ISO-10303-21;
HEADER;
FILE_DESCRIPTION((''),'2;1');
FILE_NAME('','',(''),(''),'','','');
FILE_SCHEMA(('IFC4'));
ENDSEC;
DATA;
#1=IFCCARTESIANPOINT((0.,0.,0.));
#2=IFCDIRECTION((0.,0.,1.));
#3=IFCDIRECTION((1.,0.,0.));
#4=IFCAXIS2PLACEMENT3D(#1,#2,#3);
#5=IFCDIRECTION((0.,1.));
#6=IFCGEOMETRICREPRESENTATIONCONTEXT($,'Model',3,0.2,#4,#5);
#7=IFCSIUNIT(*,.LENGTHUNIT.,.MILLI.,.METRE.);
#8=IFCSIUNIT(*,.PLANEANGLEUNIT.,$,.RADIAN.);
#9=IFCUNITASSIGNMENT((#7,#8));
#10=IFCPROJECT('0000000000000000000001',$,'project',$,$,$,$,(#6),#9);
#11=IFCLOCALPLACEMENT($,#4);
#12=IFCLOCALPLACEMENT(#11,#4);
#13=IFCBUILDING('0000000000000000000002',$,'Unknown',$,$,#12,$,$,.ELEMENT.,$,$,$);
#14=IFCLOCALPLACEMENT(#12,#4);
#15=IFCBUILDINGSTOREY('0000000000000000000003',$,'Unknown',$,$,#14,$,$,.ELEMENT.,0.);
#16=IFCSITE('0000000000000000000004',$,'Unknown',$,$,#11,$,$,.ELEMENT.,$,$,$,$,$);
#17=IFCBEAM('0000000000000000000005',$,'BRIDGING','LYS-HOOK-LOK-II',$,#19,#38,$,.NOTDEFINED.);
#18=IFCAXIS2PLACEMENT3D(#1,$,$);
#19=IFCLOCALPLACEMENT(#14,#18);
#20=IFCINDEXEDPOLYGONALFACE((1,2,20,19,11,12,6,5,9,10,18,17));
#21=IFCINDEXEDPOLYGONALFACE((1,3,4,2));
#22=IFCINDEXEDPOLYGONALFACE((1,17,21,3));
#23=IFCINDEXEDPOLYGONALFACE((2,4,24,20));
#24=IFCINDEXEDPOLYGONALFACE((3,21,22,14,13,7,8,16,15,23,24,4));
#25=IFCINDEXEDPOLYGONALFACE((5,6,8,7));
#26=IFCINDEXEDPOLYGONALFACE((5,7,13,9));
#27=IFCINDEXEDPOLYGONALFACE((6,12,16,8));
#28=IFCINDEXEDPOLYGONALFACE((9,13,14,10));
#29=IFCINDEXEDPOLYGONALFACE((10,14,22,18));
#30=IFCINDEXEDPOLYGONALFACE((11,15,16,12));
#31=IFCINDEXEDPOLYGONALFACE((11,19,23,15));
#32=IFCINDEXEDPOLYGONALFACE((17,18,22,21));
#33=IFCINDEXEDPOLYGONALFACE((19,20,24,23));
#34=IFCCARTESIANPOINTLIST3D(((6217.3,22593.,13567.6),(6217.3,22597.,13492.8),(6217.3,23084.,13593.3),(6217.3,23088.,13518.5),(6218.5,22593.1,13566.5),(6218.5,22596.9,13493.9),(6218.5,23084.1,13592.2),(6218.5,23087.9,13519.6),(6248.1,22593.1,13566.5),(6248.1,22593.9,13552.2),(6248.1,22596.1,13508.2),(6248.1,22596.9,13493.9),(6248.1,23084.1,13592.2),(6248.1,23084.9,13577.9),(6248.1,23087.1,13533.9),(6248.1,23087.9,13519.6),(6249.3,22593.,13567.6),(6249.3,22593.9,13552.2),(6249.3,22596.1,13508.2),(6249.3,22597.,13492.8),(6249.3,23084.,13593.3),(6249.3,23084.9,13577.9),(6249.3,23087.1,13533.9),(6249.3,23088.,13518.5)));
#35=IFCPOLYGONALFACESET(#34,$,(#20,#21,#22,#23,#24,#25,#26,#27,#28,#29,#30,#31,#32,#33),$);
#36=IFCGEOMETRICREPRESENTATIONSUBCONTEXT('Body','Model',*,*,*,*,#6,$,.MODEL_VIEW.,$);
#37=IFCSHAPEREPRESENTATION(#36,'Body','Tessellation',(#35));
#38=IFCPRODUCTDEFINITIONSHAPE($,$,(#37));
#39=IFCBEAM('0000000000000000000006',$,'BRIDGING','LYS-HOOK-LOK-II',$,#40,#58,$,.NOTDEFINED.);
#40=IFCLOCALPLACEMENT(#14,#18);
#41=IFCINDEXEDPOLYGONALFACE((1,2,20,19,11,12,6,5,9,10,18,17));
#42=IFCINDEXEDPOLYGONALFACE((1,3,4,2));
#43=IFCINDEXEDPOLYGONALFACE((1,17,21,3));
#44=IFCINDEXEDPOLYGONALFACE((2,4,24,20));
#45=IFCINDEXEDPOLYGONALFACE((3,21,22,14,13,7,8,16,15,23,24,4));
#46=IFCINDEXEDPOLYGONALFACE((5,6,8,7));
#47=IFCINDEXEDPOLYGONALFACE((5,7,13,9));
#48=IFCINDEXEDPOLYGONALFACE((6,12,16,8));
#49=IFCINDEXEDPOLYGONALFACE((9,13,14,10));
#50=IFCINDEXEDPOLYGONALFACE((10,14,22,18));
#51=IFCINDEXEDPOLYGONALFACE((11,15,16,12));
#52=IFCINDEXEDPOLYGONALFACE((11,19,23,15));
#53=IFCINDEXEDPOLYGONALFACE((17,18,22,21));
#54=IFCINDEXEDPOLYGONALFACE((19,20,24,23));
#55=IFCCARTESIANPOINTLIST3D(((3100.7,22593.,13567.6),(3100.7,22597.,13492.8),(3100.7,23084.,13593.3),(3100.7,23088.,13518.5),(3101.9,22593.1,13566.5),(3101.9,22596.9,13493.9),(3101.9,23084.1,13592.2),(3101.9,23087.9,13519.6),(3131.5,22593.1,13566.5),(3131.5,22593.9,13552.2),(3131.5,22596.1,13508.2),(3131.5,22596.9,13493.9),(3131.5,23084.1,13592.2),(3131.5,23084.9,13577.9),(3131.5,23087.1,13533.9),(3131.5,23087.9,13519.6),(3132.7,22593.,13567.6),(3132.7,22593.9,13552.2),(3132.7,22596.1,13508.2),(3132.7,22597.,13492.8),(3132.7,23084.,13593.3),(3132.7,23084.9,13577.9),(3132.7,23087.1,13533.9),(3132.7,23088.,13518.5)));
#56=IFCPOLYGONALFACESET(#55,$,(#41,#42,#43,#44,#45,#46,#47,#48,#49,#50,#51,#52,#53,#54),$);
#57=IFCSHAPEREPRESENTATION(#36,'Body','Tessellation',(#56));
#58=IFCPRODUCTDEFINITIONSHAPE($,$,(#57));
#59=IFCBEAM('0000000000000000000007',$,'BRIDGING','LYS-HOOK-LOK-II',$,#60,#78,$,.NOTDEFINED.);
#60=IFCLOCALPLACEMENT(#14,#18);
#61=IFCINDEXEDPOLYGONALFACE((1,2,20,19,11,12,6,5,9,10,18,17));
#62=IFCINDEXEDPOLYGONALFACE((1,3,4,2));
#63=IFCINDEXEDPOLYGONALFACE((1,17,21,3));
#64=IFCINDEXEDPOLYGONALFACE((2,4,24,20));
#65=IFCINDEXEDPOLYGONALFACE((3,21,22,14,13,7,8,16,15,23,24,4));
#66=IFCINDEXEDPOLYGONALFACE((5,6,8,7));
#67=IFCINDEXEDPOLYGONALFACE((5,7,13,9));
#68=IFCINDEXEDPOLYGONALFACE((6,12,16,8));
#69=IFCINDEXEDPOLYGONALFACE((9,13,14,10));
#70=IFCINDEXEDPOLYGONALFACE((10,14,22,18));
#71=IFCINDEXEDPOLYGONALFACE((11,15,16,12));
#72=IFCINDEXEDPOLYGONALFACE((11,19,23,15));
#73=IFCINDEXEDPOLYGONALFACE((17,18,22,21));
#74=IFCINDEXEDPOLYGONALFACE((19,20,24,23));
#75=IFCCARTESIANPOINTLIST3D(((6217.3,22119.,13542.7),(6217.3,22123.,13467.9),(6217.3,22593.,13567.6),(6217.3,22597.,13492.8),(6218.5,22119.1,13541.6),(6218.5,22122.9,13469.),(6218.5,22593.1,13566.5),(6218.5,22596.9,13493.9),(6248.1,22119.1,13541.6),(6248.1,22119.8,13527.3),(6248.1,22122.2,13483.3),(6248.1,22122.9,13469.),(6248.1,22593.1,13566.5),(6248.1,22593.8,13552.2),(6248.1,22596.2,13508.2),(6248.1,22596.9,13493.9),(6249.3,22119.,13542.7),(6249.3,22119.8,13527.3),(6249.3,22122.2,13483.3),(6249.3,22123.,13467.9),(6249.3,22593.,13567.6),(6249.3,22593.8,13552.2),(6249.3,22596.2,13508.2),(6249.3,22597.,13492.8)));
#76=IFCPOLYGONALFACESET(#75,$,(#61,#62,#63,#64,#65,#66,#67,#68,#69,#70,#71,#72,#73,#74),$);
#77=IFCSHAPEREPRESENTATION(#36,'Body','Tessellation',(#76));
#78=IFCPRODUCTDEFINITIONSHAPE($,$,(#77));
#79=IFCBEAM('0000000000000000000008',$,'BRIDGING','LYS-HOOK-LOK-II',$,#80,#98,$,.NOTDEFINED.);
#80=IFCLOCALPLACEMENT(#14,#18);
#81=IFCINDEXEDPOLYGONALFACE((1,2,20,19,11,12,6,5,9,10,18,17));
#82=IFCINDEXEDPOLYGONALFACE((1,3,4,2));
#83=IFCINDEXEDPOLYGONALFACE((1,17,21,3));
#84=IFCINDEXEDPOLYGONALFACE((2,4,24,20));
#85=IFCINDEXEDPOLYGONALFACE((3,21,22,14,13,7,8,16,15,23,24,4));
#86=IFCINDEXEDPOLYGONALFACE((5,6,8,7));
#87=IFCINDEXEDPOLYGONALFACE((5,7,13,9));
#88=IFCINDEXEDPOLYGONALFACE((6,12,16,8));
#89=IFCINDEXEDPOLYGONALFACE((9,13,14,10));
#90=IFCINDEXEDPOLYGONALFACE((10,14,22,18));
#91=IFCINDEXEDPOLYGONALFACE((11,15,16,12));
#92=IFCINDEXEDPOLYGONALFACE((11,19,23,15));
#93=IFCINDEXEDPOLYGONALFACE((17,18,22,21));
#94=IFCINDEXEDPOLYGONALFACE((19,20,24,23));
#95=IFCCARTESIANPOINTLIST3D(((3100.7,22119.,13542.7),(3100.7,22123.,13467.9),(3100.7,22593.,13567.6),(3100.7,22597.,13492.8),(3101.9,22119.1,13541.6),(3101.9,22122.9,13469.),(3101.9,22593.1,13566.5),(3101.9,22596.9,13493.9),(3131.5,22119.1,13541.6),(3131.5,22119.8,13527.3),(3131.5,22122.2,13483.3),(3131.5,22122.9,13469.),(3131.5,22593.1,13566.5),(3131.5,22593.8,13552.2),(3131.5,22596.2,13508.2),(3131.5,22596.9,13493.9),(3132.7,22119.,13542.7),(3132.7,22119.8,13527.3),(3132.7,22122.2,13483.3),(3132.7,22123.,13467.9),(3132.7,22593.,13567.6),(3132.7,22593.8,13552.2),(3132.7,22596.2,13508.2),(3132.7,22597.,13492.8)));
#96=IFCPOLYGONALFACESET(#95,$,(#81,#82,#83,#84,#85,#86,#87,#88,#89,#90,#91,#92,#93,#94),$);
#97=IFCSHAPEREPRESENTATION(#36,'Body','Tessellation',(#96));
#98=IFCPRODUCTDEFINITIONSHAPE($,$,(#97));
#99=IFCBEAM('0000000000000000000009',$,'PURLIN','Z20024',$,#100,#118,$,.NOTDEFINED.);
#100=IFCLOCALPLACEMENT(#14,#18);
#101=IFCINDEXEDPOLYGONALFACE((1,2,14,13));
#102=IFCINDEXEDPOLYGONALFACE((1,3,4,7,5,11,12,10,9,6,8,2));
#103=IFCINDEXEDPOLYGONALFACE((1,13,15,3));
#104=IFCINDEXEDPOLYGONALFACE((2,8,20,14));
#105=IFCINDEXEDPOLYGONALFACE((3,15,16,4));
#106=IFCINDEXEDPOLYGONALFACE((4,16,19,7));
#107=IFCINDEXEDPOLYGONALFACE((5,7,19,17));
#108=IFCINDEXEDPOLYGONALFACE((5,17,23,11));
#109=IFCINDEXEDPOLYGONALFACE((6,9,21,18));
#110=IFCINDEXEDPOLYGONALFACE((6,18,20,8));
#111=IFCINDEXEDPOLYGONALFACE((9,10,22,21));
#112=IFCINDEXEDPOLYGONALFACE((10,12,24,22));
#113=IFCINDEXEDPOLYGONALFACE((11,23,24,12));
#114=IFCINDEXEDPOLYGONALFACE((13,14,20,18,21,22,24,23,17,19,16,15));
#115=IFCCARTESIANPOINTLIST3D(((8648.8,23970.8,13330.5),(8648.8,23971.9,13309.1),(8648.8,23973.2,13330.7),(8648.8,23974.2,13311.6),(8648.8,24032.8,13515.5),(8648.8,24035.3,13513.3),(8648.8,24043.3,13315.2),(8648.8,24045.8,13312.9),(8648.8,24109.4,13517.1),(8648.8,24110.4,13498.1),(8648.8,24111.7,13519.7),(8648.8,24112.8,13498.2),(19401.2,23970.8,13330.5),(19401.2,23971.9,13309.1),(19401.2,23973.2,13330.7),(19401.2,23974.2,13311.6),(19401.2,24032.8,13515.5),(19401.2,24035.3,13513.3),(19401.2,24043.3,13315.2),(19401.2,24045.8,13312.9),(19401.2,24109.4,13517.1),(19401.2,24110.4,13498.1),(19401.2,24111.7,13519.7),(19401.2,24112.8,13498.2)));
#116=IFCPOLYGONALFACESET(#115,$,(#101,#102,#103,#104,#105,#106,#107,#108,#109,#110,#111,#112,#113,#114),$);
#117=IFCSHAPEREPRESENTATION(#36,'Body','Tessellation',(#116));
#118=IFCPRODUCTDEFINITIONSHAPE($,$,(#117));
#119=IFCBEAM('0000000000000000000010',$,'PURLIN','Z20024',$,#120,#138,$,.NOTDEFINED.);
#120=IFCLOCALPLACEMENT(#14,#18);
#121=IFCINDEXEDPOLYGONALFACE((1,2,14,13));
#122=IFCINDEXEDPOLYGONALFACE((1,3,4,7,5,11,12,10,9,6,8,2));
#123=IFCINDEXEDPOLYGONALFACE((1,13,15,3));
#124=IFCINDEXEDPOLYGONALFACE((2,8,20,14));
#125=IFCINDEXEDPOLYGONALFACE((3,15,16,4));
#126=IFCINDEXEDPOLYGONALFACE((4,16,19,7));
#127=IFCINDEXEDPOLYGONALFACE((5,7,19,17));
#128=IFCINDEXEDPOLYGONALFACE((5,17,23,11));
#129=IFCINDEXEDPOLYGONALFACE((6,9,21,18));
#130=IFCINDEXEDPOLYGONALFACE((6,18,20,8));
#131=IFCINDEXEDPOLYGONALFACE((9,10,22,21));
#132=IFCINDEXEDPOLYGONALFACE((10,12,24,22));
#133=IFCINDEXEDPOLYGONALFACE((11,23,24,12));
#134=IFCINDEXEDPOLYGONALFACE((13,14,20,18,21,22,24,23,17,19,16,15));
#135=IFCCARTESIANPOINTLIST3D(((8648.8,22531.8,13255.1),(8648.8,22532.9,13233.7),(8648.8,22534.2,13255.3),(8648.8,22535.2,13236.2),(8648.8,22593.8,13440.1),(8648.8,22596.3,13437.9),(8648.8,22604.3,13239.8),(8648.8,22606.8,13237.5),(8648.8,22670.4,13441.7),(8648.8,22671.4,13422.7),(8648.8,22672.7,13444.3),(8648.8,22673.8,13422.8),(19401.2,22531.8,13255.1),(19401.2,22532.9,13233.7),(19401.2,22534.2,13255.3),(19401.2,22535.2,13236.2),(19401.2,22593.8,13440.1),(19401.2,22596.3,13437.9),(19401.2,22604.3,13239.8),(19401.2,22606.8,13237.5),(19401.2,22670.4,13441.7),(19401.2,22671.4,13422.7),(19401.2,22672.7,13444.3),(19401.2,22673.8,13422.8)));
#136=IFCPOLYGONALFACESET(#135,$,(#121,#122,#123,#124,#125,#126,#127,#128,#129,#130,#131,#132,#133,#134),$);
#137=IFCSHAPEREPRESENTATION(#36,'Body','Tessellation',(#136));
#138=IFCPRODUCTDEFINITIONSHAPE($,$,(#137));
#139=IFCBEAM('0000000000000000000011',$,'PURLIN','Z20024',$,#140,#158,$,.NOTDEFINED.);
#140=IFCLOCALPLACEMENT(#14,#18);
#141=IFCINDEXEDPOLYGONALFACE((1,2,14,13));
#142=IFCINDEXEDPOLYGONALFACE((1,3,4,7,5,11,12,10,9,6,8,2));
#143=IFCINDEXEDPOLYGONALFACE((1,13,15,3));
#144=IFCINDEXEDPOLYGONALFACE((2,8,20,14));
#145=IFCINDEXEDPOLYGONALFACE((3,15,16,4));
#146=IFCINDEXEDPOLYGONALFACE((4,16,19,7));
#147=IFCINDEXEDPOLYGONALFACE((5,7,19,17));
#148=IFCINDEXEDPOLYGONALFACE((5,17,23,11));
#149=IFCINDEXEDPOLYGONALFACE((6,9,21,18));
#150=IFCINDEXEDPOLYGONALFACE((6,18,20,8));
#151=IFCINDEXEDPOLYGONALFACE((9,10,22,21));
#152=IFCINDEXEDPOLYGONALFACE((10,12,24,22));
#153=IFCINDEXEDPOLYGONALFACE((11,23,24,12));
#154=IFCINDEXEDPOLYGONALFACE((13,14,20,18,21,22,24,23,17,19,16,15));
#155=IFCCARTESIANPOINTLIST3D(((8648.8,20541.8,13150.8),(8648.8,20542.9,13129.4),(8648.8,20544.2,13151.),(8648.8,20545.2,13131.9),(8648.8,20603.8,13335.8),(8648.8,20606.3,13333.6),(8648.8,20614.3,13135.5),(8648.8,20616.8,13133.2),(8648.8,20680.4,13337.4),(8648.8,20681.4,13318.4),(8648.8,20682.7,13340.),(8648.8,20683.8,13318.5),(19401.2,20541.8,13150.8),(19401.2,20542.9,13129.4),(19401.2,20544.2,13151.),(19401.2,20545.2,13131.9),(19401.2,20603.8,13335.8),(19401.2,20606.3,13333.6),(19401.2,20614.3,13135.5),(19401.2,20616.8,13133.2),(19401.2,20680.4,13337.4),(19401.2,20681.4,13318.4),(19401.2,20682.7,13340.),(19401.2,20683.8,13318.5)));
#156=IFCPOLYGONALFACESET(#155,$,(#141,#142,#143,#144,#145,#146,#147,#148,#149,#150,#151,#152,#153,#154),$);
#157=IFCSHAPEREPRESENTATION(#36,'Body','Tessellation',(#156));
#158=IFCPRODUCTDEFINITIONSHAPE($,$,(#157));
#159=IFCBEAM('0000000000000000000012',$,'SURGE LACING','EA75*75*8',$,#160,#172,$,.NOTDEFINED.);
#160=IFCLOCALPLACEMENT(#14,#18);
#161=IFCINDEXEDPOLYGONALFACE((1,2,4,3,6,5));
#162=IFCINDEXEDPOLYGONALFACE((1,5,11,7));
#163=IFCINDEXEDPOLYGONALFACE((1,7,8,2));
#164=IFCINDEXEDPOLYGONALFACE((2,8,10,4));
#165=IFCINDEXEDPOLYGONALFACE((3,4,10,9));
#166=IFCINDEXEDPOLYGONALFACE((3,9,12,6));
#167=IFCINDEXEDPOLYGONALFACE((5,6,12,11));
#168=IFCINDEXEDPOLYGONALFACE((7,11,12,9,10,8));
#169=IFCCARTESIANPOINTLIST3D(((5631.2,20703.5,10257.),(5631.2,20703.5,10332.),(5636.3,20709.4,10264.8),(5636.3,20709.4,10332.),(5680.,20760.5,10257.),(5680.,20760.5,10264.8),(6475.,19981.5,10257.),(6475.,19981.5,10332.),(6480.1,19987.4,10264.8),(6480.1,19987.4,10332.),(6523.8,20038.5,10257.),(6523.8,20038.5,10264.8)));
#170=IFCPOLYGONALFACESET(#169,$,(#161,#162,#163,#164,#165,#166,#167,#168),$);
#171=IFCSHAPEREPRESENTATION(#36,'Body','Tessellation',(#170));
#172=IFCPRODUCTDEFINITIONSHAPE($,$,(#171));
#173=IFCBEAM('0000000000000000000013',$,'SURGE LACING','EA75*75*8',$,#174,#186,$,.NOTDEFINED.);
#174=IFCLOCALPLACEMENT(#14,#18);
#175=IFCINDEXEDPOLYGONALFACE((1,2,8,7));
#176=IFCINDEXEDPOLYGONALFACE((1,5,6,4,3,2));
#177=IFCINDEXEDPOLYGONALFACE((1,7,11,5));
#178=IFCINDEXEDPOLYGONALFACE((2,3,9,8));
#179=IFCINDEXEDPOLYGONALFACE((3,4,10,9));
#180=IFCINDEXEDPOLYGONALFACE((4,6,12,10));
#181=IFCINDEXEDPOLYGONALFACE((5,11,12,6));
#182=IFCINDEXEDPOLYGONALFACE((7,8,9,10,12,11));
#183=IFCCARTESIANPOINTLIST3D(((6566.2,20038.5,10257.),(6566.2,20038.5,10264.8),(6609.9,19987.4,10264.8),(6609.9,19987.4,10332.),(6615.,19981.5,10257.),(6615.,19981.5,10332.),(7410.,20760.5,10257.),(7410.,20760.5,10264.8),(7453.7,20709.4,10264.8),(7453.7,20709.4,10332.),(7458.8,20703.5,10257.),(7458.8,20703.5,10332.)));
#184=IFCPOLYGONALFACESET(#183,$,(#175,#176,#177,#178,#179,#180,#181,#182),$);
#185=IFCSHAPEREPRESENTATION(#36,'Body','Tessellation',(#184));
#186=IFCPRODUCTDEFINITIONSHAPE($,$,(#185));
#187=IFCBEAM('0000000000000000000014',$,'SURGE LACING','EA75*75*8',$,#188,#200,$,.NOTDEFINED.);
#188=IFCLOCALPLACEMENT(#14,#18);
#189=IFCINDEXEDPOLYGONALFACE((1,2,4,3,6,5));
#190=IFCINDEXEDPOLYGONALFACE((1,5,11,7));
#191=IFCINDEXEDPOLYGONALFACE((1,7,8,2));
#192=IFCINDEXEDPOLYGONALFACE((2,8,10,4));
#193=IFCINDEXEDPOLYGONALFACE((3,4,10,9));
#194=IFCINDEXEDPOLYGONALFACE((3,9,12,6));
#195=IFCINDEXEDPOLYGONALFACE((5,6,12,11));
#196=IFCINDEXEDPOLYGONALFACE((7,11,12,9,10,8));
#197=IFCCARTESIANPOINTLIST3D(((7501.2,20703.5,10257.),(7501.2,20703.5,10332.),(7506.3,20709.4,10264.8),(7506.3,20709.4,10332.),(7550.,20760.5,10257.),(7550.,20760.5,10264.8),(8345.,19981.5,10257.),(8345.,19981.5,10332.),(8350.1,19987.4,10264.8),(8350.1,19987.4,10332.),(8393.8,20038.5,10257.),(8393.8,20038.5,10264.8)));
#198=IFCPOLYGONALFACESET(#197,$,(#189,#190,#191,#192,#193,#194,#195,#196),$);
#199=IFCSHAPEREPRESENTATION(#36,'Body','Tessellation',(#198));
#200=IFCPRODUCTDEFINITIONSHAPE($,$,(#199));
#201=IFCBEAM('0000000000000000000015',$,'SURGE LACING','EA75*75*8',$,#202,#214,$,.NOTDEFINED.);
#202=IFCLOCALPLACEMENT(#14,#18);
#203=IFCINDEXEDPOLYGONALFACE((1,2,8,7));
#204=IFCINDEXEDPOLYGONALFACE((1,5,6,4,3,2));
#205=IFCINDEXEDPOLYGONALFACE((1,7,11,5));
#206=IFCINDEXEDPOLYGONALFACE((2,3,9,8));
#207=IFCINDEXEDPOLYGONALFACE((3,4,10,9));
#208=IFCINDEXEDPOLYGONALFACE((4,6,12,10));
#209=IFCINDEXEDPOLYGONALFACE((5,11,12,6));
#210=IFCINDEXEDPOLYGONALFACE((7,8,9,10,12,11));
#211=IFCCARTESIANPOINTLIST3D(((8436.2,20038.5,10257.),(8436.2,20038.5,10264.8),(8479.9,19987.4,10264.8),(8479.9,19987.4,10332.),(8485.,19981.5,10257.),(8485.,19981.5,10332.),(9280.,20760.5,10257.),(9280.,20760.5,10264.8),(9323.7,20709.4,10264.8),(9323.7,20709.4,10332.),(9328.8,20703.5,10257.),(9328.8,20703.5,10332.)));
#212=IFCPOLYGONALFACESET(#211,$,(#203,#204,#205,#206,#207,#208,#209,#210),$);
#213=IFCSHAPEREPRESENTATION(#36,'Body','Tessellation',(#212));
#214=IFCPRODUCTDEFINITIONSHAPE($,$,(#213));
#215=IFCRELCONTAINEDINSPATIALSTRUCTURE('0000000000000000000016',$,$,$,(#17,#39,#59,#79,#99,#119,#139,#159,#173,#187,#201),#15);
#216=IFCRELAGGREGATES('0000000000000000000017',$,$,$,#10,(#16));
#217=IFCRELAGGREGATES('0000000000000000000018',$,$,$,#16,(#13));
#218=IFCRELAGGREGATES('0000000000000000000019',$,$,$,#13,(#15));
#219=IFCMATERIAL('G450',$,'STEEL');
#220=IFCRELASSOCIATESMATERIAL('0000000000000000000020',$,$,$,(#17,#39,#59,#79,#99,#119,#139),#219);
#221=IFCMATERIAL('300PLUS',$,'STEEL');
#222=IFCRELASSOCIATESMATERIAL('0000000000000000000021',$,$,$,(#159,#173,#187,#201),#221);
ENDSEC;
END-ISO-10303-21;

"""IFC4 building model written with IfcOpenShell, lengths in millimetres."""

from ifc_helpers import new_model, si_unit, direction, frame, origin_with_axes, place, context, subcontext, project, spatial, line, indexed_curve, outline, extrude, material, element, save


model = new_model("IFC4")

# Units and contexts
model_context = context("Model", 3, precision=0.2, world=origin_with_axes(), true_north=direction((0.0, 1.0)))
body_context = subcontext(model_context, "Body", "Model", "MODEL_VIEW")
ifc_project = project(units=[si_unit("LENGTHUNIT", "METRE", prefix="MILLI"), si_unit("PLANEANGLEUNIT", "RADIAN")], contexts=[model_context])

# Site, building, storey
site_placement = place(None, origin_with_axes())
site = spatial("IfcSite", under=ifc_project, at=site_placement, Name="Unknown", CompositionType="ELEMENT")
building_placement = place(site_placement, origin_with_axes())
building = spatial("IfcBuilding", under=site, at=building_placement, Name="Unknown", CompositionType="ELEMENT")
storey_placement = place(building_placement, origin_with_axes())
storey = spatial("IfcBuildingStorey", under=building, at=storey_placement, Name="Unknown", CompositionType="ELEMENT", Elevation=0.0)

# Beams
ifc_material_1 = material(Name="G450", Category="STEEL")
for number, where, z_axis, x_axis, name in (
    (1, (6233.3, 22595.0, 13530.2), (1.0, 0.0, 0.0), (0.0, 0.998633, 0.052271), "BRIDGING"),
    (2, (3116.7, 22595.0, 13530.2), (1.0, 0.0, 0.0), (0.0, 0.998633, 0.052271), "BRIDGING"),
):
    element("IfcBeam", number, at=place(storey_placement, frame(where, z_axis=z_axis, x_axis=x_axis)), inside=storey, material=ifc_material_1, Name=name, Description="LYS-HOOK-LOK-II", PredefinedType="NOTDEFINED", context=body_context, shape_type="SolidModel", body=[
        extrude(outline(indexed_curve([(16.0, -37.5), (16.0, -22.0), (14.8, -22.0), (14.8, -36.3), (-14.8, -36.3), (-14.8, 36.3), (14.8, 36.3), (14.8, 22.0), (16.0, 22.0), (16.0, 37.5), (-16.0, 37.5), (-16.0, -37.5)], segments=[line(1, 2, 3, 4, 5, 6, 7, 8, 9, 10, 11, 12, 1)])), frame((0.0, 0.0, 0.0), z_axis=(-1.0, 0.0, 0.0), x_axis=(0.0, 0.0, 1.0)), (0.0, 0.0, -1.0), 491.7),
    ])
for number, where, z_axis, x_axis, name in (
    (3, (6233.3, 22121.0, 13505.3), (1.0, 0.0, 0.0), (0.0, 0.998623, 0.052459), "BRIDGING"),
    (4, (3116.7, 22121.0, 13505.3), (1.0, 0.0, 0.0), (0.0, 0.998623, 0.052459), "BRIDGING"),
):
    element("IfcBeam", number, at=place(storey_placement, frame(where, z_axis=z_axis, x_axis=x_axis)), inside=storey, material=ifc_material_1, Name=name, Description="LYS-HOOK-LOK-II", PredefinedType="NOTDEFINED", context=body_context, shape_type="SolidModel", body=[
        extrude(outline(indexed_curve([(16.0, -37.5), (16.0, -22.0), (14.8, -22.0), (14.8, -36.3), (-14.8, -36.3), (-14.8, 36.3), (14.8, 36.3), (14.8, 22.0), (16.0, 22.0), (16.0, 37.5), (-16.0, 37.5), (-16.0, -37.5)], segments=[line(1, 2, 3, 4, 5, 6, 7, 8, 9, 10, 11, 12, 1)])), frame((0.0, 0.0, 0.0), z_axis=(-1.0, 0.0, 0.0), x_axis=(0.0, 0.0, 1.0)), (0.0, 0.0, -1.0), 474.7),
    ])
for number, where, z_axis, x_axis, name in (
    (5, (8648.8, 24039.3, 13414.2), (0.0, -0.99863, -0.052336), (1.0, 0.0, 0.0), "PURLIN"),
    (6, (8648.8, 22600.3, 13338.8), (0.0, -0.99863, -0.052336), (1.0, 0.0, 0.0), "PURLIN"),
    (7, (8648.8, 20610.3, 13234.5), (0.0, -0.99863, -0.052336), (1.0, 0.0, 0.0), "PURLIN"),
):
    element("IfcBeam", number, at=place(storey_placement, frame(where, z_axis=z_axis, x_axis=x_axis)), inside=storey, material=ifc_material_1, Name=name, Description="Z20024", PredefinedType="NOTDEFINED", context=body_context, shape_type="SolidModel", body=[
        extrude(outline(indexed_curve([(72.8, -101.5), (72.8, -80.0), (70.4, -80.0), (70.4, -99.1), (1.2, -99.1), (1.2, 101.5), (-77.8, 101.5), (-77.8, 80.0), (-75.4, 80.0), (-75.4, 99.1), (-1.2, 99.1), (-1.2, -101.5)], segments=[line(1, 2, 3, 4, 5, 6, 7, 8, 9, 10, 11, 12, 1)])), frame((0.0, 0.0, 0.0), z_axis=(-1.0, 0.0, 0.0), x_axis=(0.0, 0.0, 1.0)), (0.0, 0.0, -1.0), 10752.4),
    ])
ifc_material_2 = material(Name="300PLUS", Category="STEEL")
for number, where, z_axis, x_axis, name in (
    (8, (5655.6, 20732.0, 10294.5), (0.0, 0.0, 1.0), (0.759816, -0.650139, 0.0), "SURGE LACING"),
    (9, (6590.6, 20010.0, 10294.5), (0.0, 0.0, 1.0), (0.759816, 0.650139, 0.0), "SURGE LACING"),
    (10, (7525.6, 20732.0, 10294.5), (0.0, 0.0, 1.0), (0.759816, -0.650139, 0.0), "SURGE LACING"),
    (11, (8460.6, 20010.0, 10294.5), (0.0, 0.0, 1.0), (0.759816, 0.650139, 0.0), "SURGE LACING"),
):
    element("IfcBeam", number, at=place(storey_placement, frame(where, z_axis=z_axis, x_axis=x_axis)), inside=storey, material=ifc_material_2, Name=name, Description="EA75*75*8", PredefinedType="NOTDEFINED", context=body_context, shape_type="SolidModel", body=[
        extrude(outline(indexed_curve([(-37.5, -37.5), (37.5, -37.5), (37.5, -29.7), (-29.7, -29.7), (-29.7, 37.5), (-37.5, 37.5)], segments=[line(1, 2, 3, 4, 5, 6, 1)])), frame((0.0, 0.0, 0.0), z_axis=(-1.0, 0.0, 0.0), x_axis=(0.0, 0.0, 1.0)), (0.0, 0.0, -1.0), 1110.5),
    ])

save(model, "model.ifc")
